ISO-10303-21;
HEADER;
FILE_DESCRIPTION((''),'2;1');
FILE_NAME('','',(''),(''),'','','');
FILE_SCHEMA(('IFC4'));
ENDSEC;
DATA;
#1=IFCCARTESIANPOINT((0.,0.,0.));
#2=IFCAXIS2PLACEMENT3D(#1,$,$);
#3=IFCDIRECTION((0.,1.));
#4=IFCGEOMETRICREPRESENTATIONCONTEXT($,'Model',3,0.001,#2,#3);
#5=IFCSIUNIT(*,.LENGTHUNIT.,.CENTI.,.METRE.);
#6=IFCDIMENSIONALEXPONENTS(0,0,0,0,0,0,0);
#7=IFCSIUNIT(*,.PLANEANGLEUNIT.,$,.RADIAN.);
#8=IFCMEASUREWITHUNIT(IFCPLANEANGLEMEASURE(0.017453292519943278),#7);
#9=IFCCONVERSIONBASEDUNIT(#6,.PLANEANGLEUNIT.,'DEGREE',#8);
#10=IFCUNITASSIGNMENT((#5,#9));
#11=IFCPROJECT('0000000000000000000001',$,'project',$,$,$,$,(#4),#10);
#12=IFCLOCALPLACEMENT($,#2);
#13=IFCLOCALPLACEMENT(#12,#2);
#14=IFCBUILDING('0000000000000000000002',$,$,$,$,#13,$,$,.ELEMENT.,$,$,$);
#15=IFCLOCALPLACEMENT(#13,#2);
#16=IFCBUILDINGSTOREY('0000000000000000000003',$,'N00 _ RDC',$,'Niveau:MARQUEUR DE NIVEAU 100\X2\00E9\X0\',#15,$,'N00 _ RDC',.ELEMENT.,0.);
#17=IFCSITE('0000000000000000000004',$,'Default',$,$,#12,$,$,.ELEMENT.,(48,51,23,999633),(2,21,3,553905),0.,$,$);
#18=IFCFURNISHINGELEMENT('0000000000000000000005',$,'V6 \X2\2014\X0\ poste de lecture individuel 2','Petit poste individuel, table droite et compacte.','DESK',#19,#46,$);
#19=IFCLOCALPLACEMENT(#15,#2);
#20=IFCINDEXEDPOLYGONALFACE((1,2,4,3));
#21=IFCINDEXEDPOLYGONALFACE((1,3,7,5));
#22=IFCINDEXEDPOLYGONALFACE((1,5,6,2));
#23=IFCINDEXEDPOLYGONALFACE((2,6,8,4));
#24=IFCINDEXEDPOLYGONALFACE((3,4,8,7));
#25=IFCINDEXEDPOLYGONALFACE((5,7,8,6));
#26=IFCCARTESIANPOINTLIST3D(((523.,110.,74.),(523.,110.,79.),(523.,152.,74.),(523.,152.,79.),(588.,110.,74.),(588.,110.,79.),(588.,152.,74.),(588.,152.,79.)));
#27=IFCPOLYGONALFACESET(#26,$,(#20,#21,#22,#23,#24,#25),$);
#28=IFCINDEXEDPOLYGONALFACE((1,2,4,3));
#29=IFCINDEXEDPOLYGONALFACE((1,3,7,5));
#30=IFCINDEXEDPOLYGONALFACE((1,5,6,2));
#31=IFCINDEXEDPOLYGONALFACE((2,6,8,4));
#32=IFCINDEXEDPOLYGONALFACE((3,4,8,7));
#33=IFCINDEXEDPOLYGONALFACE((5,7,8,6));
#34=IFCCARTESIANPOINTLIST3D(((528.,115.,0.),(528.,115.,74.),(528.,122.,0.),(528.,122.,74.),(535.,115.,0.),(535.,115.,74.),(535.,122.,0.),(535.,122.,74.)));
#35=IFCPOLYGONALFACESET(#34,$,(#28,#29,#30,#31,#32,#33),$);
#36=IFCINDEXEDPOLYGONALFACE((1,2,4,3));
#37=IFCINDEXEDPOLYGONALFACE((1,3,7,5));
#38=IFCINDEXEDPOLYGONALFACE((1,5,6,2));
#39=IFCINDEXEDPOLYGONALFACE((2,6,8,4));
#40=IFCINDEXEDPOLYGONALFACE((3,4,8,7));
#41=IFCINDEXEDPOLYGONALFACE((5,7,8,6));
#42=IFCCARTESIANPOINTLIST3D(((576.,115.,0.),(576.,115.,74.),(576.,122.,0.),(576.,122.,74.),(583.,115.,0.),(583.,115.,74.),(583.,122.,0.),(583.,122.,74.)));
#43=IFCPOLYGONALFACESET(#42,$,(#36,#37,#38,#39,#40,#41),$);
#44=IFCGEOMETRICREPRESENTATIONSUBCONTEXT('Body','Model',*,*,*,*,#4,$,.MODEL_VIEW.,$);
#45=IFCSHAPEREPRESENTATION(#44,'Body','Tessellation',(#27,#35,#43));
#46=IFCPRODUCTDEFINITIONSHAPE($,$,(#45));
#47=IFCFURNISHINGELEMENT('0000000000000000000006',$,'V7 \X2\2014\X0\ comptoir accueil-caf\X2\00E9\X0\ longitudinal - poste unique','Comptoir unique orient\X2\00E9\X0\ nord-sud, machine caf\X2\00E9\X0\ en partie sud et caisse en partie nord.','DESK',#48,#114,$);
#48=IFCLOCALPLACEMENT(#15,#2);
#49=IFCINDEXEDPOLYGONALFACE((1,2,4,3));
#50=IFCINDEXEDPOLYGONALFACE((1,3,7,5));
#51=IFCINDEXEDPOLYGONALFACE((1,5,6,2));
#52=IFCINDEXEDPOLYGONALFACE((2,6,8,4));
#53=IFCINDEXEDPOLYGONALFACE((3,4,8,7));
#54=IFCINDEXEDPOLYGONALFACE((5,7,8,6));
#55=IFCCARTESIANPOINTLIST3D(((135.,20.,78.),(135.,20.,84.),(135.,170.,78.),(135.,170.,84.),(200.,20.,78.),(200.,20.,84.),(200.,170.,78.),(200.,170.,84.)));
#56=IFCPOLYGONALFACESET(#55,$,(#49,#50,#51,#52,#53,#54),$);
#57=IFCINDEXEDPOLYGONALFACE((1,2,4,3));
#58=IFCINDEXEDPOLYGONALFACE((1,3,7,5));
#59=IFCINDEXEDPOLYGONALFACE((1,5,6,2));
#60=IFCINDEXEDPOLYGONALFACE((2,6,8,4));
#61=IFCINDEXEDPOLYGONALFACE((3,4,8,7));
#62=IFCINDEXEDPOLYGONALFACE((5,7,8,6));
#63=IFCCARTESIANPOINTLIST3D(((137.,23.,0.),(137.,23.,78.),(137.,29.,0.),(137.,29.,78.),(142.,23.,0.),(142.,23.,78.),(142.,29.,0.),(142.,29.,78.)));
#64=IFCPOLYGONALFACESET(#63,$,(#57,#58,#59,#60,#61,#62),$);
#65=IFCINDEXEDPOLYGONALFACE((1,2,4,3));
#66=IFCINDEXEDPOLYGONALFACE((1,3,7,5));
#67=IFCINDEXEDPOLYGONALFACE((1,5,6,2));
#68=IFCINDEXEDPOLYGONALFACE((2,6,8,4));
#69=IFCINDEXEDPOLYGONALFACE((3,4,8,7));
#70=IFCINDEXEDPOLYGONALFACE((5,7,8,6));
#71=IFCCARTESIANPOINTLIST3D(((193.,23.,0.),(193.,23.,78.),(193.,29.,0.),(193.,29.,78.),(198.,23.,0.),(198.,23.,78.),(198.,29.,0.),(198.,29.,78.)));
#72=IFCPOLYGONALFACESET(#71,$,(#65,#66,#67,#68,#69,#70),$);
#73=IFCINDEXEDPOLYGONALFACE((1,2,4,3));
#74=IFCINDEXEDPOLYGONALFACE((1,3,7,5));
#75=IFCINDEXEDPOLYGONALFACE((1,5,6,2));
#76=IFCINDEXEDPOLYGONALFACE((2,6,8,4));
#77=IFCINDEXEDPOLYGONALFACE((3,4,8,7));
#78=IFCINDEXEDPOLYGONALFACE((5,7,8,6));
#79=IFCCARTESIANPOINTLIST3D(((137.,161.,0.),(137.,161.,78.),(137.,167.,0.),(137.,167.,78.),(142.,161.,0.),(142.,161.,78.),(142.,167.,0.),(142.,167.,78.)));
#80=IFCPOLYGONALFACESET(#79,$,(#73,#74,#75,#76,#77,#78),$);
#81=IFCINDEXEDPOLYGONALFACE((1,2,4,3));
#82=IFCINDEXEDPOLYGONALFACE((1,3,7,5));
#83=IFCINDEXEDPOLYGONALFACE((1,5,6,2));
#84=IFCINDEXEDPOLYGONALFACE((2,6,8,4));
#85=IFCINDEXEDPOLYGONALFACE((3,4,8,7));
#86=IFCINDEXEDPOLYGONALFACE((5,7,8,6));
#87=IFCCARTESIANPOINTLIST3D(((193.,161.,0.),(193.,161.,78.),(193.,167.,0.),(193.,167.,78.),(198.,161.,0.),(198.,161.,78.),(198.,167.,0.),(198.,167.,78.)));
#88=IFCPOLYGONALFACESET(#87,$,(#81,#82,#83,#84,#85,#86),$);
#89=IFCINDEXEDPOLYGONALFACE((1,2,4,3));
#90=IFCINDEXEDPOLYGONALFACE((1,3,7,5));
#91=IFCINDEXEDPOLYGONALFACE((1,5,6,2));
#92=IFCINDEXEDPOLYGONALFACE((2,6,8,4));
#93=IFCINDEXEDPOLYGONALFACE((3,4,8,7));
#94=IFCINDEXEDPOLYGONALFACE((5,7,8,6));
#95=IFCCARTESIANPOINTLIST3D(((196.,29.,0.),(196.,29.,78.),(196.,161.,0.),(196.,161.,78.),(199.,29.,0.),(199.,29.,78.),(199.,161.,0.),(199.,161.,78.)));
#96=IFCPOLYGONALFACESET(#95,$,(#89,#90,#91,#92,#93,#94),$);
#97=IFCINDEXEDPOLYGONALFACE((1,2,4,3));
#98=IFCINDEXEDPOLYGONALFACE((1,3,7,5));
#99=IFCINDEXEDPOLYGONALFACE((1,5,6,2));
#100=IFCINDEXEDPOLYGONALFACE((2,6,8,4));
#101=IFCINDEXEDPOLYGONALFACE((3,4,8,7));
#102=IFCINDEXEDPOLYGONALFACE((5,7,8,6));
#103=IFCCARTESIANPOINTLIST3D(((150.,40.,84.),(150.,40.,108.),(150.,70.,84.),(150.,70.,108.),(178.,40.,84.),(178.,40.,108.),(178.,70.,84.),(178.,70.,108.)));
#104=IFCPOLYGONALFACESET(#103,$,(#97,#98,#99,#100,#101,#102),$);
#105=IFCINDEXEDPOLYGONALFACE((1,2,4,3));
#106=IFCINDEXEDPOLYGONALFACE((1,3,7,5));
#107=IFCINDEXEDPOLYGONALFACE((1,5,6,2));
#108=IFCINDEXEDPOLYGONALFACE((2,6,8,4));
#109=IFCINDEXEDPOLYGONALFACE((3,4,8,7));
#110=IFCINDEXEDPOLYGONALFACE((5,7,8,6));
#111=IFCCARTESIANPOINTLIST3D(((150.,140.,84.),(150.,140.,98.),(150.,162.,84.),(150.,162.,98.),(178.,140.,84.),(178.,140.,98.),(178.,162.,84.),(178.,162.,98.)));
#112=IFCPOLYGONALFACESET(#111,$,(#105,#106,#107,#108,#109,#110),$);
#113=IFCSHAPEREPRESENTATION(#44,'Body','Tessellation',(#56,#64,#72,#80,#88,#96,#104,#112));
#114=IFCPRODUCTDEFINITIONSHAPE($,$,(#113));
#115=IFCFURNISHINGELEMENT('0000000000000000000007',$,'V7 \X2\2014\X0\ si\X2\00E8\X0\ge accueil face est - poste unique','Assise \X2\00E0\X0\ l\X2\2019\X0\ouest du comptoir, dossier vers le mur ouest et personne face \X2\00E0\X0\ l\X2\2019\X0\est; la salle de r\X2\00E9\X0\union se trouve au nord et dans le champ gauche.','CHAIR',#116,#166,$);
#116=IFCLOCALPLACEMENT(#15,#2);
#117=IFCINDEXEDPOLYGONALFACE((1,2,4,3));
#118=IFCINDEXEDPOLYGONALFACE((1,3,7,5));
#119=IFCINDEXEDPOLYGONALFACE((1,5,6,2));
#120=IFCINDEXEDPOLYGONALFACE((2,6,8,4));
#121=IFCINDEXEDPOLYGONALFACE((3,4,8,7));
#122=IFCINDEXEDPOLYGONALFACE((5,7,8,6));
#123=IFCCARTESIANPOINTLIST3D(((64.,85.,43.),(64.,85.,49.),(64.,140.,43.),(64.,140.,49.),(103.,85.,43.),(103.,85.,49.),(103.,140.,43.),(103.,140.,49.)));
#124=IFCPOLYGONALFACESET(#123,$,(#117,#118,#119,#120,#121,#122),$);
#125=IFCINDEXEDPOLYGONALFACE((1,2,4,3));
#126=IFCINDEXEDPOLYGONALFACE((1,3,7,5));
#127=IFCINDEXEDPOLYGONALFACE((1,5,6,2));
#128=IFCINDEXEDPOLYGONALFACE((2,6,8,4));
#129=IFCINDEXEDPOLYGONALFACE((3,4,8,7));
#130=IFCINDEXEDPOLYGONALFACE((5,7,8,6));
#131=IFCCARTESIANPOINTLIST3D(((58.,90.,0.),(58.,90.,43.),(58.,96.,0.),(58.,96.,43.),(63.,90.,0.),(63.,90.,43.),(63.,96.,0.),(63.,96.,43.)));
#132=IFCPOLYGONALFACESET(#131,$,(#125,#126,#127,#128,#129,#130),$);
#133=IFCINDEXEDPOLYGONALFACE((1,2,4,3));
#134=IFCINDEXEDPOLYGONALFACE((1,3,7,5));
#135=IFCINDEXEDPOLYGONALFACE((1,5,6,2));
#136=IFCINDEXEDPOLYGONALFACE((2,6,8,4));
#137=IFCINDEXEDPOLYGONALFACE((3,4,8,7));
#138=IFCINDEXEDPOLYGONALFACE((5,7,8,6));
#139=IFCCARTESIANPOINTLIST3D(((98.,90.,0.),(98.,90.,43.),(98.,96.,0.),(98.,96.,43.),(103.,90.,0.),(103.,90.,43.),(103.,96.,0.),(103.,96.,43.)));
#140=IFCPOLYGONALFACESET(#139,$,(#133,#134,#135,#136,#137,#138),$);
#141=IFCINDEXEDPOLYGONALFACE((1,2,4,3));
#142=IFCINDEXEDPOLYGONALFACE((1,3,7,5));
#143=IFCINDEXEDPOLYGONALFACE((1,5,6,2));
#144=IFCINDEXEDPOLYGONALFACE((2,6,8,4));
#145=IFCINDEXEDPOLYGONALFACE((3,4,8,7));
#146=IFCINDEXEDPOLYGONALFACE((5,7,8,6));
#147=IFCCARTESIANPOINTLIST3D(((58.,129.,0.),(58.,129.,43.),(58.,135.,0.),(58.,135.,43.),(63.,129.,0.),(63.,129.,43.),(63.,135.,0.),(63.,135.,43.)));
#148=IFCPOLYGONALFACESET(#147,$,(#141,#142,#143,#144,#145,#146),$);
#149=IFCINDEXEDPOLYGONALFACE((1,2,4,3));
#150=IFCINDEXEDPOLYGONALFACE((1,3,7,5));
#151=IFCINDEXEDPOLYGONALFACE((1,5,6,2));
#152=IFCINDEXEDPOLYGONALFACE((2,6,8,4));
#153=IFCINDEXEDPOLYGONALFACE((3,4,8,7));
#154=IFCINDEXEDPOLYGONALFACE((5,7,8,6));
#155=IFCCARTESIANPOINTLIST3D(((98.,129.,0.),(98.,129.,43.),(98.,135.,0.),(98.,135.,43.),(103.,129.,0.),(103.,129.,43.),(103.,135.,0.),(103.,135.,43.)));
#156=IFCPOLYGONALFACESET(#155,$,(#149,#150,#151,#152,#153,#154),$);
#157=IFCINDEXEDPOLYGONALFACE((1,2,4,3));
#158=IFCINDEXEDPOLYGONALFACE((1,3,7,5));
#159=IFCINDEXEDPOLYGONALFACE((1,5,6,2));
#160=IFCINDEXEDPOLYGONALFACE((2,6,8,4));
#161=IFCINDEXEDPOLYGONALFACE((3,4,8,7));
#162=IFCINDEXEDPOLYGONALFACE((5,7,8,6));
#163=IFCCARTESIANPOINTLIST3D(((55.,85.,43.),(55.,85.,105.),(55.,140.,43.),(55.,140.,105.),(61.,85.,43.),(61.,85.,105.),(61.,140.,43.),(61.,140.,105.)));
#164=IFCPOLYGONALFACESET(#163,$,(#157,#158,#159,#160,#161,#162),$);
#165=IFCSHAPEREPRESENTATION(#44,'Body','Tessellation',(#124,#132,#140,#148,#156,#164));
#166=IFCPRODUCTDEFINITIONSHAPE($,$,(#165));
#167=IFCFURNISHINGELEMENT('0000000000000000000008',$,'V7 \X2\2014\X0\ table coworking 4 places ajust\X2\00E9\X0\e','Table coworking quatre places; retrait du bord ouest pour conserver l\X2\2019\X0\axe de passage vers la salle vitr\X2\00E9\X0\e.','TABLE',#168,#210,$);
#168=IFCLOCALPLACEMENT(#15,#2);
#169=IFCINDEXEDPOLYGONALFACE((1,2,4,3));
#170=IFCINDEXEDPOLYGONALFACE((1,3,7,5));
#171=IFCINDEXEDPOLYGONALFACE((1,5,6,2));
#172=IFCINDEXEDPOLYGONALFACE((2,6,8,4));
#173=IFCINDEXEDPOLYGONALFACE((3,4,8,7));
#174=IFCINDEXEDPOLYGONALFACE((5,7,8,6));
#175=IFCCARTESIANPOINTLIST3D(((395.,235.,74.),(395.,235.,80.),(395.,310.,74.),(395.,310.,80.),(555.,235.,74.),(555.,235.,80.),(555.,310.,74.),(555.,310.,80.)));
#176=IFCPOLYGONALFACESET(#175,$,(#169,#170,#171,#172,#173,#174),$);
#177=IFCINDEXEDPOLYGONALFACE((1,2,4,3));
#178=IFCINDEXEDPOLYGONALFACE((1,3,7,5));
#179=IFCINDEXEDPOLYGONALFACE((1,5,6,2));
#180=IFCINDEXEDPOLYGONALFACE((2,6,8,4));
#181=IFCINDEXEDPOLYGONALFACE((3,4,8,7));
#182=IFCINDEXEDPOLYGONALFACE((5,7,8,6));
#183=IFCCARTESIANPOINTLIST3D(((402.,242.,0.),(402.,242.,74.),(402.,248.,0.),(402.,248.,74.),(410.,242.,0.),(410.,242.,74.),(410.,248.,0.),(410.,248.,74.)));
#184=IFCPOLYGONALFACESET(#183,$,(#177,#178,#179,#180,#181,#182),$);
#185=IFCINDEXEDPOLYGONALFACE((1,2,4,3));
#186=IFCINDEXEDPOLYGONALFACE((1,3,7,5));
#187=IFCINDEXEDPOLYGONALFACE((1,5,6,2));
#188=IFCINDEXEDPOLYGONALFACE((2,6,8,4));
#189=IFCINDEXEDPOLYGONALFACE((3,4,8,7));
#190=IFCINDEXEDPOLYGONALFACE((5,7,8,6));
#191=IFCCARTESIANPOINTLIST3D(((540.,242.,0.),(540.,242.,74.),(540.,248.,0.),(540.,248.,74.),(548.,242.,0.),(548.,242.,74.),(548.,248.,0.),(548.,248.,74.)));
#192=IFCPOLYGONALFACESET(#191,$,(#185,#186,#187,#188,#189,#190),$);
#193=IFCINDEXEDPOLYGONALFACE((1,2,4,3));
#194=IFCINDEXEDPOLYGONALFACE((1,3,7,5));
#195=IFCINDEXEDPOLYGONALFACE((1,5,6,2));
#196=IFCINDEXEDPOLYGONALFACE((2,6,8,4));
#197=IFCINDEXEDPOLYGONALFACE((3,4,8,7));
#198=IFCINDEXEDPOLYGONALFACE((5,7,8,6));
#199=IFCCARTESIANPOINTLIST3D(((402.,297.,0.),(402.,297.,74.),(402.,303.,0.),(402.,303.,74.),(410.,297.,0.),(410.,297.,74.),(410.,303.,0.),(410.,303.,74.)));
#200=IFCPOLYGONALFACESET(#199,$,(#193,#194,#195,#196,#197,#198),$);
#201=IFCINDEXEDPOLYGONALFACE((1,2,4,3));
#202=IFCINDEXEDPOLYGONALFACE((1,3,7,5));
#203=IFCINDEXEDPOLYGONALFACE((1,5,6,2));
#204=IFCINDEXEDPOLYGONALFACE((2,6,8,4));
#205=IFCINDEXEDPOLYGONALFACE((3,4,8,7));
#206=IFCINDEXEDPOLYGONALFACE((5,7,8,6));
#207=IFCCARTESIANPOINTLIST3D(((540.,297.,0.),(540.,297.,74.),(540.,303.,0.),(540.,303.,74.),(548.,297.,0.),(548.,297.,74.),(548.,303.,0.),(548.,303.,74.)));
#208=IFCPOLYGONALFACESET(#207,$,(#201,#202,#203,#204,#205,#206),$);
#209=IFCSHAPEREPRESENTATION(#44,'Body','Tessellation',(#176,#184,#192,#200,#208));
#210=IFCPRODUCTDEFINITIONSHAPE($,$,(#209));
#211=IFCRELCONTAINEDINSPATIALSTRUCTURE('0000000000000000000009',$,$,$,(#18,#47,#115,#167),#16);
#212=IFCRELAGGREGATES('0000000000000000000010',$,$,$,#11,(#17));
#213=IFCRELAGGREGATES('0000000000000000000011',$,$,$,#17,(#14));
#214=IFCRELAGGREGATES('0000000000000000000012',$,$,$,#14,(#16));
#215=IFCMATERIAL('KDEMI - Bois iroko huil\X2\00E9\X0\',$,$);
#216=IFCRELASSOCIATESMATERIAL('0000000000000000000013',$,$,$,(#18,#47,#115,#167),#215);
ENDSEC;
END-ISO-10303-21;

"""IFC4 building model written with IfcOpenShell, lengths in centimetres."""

from ifc_helpers import new_model, entity, si_unit, converted_unit, direction, frame, frame_2d, origin, origin_with_axes, place, context, subcontext, project, spatial, rectangle, extrude, material, element, save


model = new_model("IFC4")

# Units and contexts
model_context = context("Model", 3, precision=0.001, world=origin(), true_north=direction((0.0, 1.0)))
body_context = subcontext(model_context, "Body", "Model", "MODEL_VIEW")
ifc_project = project(units=[si_unit("LENGTHUNIT", "METRE", prefix="CENTI"), converted_unit("PLANEANGLEUNIT", "DEGREE", entity("IfcPlaneAngleMeasure", 0.017453292519943278), si_unit("PLANEANGLEUNIT", "RADIAN"), dimensions=[0, 0, 0, 0, 0, 0, 0])], contexts=[model_context])

# Site, building, storey
site_placement = place(None, origin())
site = spatial("IfcSite", under=ifc_project, at=site_placement, Name="Default", CompositionType="ELEMENT", RefLatitude=(48, 51, 23, 999633), RefLongitude=(2, 21, 3, 553905), RefElevation=0.0)
building_placement = place(site_placement, origin())
building = spatial("IfcBuilding", under=site, at=building_placement, CompositionType="ELEMENT")
storey_placement = place(building_placement, origin())
storey = spatial("IfcBuildingStorey", under=building, at=storey_placement, Name="N00 _ RDC", ObjectType="Niveau:MARQUEUR DE NIVEAU 100é", LongName="N00 _ RDC", CompositionType="ELEMENT", Elevation=0.0)

# Shared definitions
ifc_material_1 = material(Name="KDEMI - Bois iroko huilé")

# Furnishing elements
furnishing_1_placement = place(storey_placement, origin_with_axes())
element("IfcFurnishingElement", 1, at=furnishing_1_placement, inside=storey, material=ifc_material_1, Name="V6 — poste de lecture individuel 2", Description="Petit poste individuel, table droite et compacte.", ObjectType="DESK", context=body_context, shape_type="SweptSolid", body=[
    extrude(rectangle(XDim=65.0, YDim=42.0, at=frame_2d((555.5, 131.0))), frame((0.0, 0.0, 74.0)), (0.0, 0.0, 1.0), 5.0),
    extrude(rectangle(XDim=7.0, YDim=7.0, at=frame_2d((531.5, 118.5))), origin(), (0.0, 0.0, 1.0), 74.0),
    extrude(rectangle(XDim=7.0, YDim=7.0, at=frame_2d((579.5, 118.5))), origin(), (0.0, 0.0, 1.0), 74.0),
])
furnishing_2_placement = place(storey_placement, origin_with_axes())
element("IfcFurnishingElement", 2, at=furnishing_2_placement, inside=storey, material=ifc_material_1, Name="V7 — comptoir accueil-café longitudinal - poste unique", Description="Comptoir unique orienté nord-sud, machine café en partie sud et caisse en partie nord.", ObjectType="DESK", context=body_context, shape_type="SweptSolid", body=[
    extrude(rectangle(XDim=65.0, YDim=150.0, at=frame_2d((167.5, 95.0))), frame((0.0, 0.0, 78.0)), (0.0, 0.0, 1.0), 6.0),
    extrude(rectangle(XDim=5.0, YDim=6.0, at=frame_2d((139.5, 26.0))), origin(), (0.0, 0.0, 1.0), 78.0),
    extrude(rectangle(XDim=5.0, YDim=6.0, at=frame_2d((195.5, 26.0))), origin(), (0.0, 0.0, 1.0), 78.0),
    extrude(rectangle(XDim=5.0, YDim=6.0, at=frame_2d((139.5, 164.0))), origin(), (0.0, 0.0, 1.0), 78.0),
    extrude(rectangle(XDim=5.0, YDim=6.0, at=frame_2d((195.5, 164.0))), origin(), (0.0, 0.0, 1.0), 78.0),
    extrude(rectangle(XDim=3.0, YDim=132.0, at=frame_2d((197.5, 95.0))), origin(), (0.0, 0.0, 1.0), 78.0),
    extrude(rectangle(XDim=28.0, YDim=30.0, at=frame_2d((164.0, 55.0))), frame((0.0, 0.0, 84.0)), (0.0, 0.0, 1.0), 24.0),
    extrude(rectangle(XDim=28.0, YDim=22.0, at=frame_2d((164.0, 151.0))), frame((0.0, 0.0, 84.0)), (0.0, 0.0, 1.0), 14.0),
])
furnishing_3_placement = place(storey_placement, origin_with_axes())
element("IfcFurnishingElement", 3, at=furnishing_3_placement, inside=storey, material=ifc_material_1, Name="V7 — siège accueil face est - poste unique", Description="Assise à l’ouest du comptoir, dossier vers le mur ouest et personne face à l’est; la salle de réunion se trouve au nord et dans le champ gauche.", ObjectType="CHAIR", context=body_context, shape_type="SweptSolid", body=[
    extrude(rectangle(XDim=39.0, YDim=55.0, at=frame_2d((83.5, 112.5))), frame((0.0, 0.0, 43.0)), (0.0, 0.0, 1.0), 6.0),
    extrude(rectangle(XDim=5.0, YDim=6.0, at=frame_2d((60.5, 93.0))), origin(), (0.0, 0.0, 1.0), 43.0),
    extrude(rectangle(XDim=5.0, YDim=6.0, at=frame_2d((100.5, 93.0))), origin(), (0.0, 0.0, 1.0), 43.0),
    extrude(rectangle(XDim=5.0, YDim=6.0, at=frame_2d((60.5, 132.0))), origin(), (0.0, 0.0, 1.0), 43.0),
    extrude(rectangle(XDim=5.0, YDim=6.0, at=frame_2d((100.5, 132.0))), origin(), (0.0, 0.0, 1.0), 43.0),
    extrude(rectangle(XDim=6.0, YDim=55.0, at=frame_2d((58.0, 112.5))), frame((0.0, 0.0, 43.0)), (0.0, 0.0, 1.0), 62.0),
])
furnishing_4_placement = place(storey_placement, origin_with_axes())
element("IfcFurnishingElement", 4, at=furnishing_4_placement, inside=storey, material=ifc_material_1, Name="V7 — table coworking 4 places ajustée", Description="Table coworking quatre places; retrait du bord ouest pour conserver l’axe de passage vers la salle vitrée.", ObjectType="TABLE", context=body_context, shape_type="SweptSolid", body=[
    extrude(rectangle(XDim=160.0, YDim=75.0, at=frame_2d((475.0, 272.5))), frame((0.0, 0.0, 74.0)), (0.0, 0.0, 1.0), 6.0),
    extrude(rectangle(XDim=8.0, YDim=6.0, at=frame_2d((406.0, 245.0))), origin(), (0.0, 0.0, 1.0), 74.0),
    extrude(rectangle(XDim=8.0, YDim=6.0, at=frame_2d((544.0, 245.0))), origin(), (0.0, 0.0, 1.0), 74.0),
    extrude(rectangle(XDim=8.0, YDim=6.0, at=frame_2d((406.0, 300.0))), origin(), (0.0, 0.0, 1.0), 74.0),
    extrude(rectangle(XDim=8.0, YDim=6.0, at=frame_2d((544.0, 300.0))), origin(), (0.0, 0.0, 1.0), 74.0),
])

save(model, "model.ifc")
